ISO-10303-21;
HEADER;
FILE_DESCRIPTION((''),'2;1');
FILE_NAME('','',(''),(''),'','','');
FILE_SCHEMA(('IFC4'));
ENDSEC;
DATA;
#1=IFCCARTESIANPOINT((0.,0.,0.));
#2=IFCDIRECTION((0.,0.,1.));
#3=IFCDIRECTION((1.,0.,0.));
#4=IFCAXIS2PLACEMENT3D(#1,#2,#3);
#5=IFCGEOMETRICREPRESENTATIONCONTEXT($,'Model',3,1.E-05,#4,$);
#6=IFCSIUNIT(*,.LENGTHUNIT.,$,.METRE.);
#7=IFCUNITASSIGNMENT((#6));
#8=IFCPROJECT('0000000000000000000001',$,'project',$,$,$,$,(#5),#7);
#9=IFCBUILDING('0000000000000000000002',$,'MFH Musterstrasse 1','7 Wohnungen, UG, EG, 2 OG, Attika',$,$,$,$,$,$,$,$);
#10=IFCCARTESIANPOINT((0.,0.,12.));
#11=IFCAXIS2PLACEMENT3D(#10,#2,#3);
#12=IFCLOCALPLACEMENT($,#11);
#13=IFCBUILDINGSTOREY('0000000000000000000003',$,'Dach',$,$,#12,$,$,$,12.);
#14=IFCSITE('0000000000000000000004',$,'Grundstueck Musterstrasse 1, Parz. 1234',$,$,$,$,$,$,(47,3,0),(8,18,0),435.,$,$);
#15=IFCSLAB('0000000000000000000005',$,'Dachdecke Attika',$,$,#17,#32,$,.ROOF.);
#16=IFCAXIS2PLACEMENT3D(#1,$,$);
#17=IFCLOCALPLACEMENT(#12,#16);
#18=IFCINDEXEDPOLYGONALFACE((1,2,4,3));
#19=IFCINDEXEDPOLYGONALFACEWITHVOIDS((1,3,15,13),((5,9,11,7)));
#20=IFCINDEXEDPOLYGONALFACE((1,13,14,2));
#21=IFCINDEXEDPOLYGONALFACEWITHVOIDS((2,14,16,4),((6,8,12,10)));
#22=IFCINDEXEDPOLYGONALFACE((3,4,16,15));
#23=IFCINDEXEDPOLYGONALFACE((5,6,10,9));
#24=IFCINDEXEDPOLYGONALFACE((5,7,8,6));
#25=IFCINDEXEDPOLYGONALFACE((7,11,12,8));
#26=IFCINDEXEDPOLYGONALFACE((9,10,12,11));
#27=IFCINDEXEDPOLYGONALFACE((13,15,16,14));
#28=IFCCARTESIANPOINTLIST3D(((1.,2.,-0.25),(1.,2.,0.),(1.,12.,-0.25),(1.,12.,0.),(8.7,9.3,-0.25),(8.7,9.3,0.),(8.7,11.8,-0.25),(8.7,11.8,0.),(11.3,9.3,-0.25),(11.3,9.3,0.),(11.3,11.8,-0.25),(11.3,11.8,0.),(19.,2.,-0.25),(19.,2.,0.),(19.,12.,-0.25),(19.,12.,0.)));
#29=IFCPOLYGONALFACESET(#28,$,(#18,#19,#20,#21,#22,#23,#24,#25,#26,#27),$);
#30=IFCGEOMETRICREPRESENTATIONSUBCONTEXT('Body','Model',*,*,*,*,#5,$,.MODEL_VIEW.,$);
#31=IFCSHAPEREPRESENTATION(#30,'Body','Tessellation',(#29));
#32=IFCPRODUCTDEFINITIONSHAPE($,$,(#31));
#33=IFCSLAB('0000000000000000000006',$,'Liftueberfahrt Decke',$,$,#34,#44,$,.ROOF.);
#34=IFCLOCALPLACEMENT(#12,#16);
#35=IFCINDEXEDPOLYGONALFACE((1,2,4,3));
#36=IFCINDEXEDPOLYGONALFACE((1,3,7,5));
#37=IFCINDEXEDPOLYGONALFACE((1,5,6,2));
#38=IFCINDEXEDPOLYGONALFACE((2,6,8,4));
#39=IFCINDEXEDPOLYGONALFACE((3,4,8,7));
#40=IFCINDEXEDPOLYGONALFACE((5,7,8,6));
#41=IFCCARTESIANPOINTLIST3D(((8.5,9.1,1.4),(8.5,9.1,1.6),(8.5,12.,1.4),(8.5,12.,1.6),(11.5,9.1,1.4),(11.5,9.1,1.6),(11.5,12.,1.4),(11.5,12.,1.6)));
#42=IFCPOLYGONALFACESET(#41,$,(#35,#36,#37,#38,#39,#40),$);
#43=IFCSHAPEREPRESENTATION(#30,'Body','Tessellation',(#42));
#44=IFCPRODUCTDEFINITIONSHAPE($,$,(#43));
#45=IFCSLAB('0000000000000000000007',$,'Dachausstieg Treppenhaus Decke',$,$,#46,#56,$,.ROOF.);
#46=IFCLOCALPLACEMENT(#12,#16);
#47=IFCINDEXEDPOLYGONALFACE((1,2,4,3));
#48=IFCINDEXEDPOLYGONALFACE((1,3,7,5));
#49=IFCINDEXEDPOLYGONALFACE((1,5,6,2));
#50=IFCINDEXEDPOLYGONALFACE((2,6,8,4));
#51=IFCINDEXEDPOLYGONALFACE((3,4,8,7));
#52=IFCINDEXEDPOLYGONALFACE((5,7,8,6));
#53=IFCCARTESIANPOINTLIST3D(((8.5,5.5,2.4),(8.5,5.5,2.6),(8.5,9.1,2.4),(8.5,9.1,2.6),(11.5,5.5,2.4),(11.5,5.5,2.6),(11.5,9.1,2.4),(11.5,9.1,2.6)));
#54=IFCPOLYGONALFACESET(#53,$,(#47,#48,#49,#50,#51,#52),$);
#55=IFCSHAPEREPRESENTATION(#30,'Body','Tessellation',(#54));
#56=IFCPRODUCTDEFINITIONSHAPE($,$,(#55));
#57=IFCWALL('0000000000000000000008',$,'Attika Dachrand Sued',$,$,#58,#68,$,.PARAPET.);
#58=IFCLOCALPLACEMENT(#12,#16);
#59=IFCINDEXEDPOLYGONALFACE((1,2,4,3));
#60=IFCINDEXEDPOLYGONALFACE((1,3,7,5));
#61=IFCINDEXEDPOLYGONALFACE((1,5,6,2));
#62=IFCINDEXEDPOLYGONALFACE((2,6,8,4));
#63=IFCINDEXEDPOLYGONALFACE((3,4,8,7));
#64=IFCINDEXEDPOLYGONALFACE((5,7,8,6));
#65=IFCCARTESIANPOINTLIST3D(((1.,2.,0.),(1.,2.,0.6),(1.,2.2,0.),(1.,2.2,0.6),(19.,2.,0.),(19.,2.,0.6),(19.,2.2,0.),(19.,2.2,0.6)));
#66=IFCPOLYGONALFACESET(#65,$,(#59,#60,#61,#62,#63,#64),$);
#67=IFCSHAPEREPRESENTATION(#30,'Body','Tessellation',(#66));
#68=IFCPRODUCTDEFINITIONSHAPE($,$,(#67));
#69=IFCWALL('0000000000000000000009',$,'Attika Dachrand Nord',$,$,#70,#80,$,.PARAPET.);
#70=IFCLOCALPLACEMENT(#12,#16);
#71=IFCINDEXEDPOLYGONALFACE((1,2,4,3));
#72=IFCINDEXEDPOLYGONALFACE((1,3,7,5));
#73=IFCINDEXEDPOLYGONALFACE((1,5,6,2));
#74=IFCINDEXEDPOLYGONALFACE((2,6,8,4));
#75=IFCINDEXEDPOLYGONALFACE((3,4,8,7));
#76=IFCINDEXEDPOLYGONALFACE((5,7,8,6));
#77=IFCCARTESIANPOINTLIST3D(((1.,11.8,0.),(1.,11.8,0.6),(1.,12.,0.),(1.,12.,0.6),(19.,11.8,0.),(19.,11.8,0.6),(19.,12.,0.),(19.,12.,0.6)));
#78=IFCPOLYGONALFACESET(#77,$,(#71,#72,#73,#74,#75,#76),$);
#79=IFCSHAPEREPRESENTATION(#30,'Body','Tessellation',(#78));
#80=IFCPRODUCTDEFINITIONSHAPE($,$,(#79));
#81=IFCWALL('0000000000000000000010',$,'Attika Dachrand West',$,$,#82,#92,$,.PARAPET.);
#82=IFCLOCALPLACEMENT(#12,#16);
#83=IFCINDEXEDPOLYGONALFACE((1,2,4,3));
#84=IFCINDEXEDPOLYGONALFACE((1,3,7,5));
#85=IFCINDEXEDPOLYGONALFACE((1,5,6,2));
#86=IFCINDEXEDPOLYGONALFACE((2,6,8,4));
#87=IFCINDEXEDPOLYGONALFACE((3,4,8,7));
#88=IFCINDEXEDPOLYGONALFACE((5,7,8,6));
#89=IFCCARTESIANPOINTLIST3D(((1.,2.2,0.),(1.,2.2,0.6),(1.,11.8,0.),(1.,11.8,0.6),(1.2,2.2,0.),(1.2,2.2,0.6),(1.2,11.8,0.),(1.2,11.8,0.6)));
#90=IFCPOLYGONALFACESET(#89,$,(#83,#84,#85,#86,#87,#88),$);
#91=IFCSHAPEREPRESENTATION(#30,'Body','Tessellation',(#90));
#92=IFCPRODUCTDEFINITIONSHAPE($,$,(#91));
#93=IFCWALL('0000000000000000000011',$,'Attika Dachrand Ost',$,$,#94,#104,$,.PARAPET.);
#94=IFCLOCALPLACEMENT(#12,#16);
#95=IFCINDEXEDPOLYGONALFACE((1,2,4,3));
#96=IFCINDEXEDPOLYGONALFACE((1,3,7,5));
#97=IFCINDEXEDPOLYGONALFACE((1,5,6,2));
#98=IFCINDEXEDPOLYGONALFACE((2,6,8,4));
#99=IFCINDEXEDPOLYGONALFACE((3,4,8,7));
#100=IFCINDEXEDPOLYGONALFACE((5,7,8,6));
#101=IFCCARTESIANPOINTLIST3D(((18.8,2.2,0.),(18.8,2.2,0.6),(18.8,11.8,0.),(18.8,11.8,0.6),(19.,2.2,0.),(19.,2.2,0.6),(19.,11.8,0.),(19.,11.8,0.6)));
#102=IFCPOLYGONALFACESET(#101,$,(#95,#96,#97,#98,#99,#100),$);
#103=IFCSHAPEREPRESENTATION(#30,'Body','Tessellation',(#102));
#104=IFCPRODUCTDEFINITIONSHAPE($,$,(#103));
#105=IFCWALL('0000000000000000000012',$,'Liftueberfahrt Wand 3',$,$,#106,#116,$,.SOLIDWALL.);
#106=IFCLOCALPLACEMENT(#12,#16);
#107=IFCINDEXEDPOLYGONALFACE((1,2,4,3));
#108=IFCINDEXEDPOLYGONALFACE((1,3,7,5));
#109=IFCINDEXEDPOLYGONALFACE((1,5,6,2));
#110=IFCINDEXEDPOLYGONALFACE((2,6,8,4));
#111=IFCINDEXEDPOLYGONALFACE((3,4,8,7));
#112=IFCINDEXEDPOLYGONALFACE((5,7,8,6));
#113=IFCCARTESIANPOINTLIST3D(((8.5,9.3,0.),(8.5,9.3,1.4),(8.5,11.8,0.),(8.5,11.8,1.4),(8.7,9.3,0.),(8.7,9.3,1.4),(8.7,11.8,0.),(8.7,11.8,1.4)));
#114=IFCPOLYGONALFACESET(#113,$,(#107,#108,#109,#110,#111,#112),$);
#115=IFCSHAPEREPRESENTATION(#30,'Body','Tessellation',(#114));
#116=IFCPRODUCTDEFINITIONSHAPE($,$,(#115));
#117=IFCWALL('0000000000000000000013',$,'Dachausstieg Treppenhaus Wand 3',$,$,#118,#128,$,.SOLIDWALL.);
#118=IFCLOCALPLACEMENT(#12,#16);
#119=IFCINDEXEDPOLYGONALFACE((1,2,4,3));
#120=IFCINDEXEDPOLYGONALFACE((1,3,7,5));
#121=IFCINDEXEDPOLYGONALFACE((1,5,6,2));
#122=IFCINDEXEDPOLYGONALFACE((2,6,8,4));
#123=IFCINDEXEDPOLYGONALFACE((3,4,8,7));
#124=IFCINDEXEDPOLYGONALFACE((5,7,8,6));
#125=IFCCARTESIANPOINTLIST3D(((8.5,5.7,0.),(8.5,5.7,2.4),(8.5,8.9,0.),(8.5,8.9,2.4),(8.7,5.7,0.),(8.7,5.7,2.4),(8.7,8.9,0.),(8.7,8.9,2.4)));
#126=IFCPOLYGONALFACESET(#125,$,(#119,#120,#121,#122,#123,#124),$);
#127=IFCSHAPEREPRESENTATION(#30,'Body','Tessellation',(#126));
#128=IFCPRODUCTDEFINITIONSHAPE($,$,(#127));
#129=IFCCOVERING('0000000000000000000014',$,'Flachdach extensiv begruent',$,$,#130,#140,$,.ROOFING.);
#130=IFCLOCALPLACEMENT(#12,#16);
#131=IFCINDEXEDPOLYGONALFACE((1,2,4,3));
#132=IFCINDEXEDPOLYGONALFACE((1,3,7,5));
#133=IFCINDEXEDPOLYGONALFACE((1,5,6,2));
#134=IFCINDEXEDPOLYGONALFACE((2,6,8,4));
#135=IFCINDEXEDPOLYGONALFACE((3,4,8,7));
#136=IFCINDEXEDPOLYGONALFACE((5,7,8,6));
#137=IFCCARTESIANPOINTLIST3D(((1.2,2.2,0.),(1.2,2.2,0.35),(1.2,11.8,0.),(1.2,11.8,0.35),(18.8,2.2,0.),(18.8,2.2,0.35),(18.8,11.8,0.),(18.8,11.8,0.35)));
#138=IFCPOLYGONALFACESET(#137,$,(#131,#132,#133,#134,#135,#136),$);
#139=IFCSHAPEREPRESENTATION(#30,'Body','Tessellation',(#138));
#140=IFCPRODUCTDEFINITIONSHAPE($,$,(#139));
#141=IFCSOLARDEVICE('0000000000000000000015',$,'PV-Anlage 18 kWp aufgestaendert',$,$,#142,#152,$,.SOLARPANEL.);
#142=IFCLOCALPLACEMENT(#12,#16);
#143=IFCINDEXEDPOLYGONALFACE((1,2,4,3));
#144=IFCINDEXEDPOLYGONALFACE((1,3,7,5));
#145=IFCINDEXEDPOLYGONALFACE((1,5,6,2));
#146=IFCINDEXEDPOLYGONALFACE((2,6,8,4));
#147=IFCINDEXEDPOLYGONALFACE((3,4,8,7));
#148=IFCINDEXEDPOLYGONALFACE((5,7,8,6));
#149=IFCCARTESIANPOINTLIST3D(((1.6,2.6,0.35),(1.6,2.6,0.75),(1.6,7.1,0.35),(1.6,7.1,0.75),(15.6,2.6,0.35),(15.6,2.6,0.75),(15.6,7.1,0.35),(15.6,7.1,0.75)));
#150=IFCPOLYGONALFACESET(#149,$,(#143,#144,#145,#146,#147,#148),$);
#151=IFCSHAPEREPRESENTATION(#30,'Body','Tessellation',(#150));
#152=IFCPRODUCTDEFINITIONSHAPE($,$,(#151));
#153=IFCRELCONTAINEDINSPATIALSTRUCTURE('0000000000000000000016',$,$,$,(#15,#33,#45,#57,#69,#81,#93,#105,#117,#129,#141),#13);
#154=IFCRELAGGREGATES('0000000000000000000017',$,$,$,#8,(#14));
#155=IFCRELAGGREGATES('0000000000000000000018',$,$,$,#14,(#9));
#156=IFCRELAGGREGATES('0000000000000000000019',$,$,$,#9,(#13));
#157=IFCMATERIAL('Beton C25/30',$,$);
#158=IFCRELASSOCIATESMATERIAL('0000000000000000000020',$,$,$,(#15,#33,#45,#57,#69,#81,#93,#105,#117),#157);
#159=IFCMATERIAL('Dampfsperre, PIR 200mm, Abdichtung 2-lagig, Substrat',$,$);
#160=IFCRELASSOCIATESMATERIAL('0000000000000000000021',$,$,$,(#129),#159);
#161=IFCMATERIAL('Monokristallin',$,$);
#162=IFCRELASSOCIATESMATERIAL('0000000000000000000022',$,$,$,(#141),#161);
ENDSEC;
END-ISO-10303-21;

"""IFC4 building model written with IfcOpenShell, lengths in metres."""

from ifc_helpers import new_model, si_unit, frame, frame_2d, origin_with_axes, place, context, subcontext, project, spatial, polyline, rectangle, outline, extrude, material, element, save


model = new_model("IFC4")

# Units and contexts
model_context = context("Model", 3, precision=1e-05, world=origin_with_axes())
body_context = subcontext(model_context, "Body", "Model", "MODEL_VIEW")
ifc_project = project(units=[si_unit("LENGTHUNIT", "METRE")], contexts=[model_context])

# Site, building, storey
site = spatial("IfcSite", under=ifc_project, Name="Grundstueck Musterstrasse 1, Parz. 1234", RefLatitude=(47, 3, 0), RefLongitude=(8, 18, 0), RefElevation=435.0)
building = spatial("IfcBuilding", under=site, Name="MFH Musterstrasse 1", Description="7 Wohnungen, UG, EG, 2 OG, Attika")
storey_placement = place(None, frame((0.0, 0.0, 12.0), z_axis=(0.0, 0.0, 1.0), x_axis=(1.0, 0.0, 0.0)))
storey = spatial("IfcBuildingStorey", under=building, at=storey_placement, Name="Dach", Elevation=12.0)

# Slab, opening
ifc_material_1 = material(Name="Beton C25/30")
slab_1_placement = place(storey_placement, frame((0.0, 0.0, -0.25), z_axis=(0.0, 0.0, 1.0), x_axis=(1.0, 0.0, 0.0)))
slab_1 = element("IfcSlab", 1, at=slab_1_placement, inside=storey, material=ifc_material_1, Name="Dachdecke Attika", PredefinedType="ROOF", context=body_context, shape_type="SweptSolid", body=[
    extrude(outline(polyline([(1.0, 2.0), (19.0, 2.0), (19.0, 12.0), (1.0, 12.0), (1.0, 2.0)])), origin_with_axes(), (0.0, 0.0, 1.0), 0.25),
])
opening_placement = place(slab_1_placement, frame((8.7, 9.3, -0.01), z_axis=(0.0, 0.0, 1.0), x_axis=(1.0, 0.0, 0.0)))
element("IfcOpeningElement", 2, at=opening_placement, cuts=slab_1, context=body_context, shape_type="SweptSolid", body=[
    extrude(rectangle(XDim=2.6, YDim=2.5, at=frame_2d((1.3, 1.25))), origin_with_axes(), (0.0, 0.0, 1.0), 0.27),
])

# Slabs
slab_2_placement = place(storey_placement, frame((0.0, 0.0, 1.4), z_axis=(0.0, 0.0, 1.0), x_axis=(1.0, 0.0, 0.0)))
element("IfcSlab", 3, at=slab_2_placement, inside=storey, material=ifc_material_1, Name="Liftueberfahrt Decke", PredefinedType="ROOF", context=body_context, shape_type="SweptSolid", body=[
    extrude(outline(polyline([(8.5, 9.1), (11.5, 9.1), (11.5, 12.0), (8.5, 12.0), (8.5, 9.1)])), origin_with_axes(), (0.0, 0.0, 1.0), 0.2),
])
slab_3_placement = place(storey_placement, frame((0.0, 0.0, 2.4), z_axis=(0.0, 0.0, 1.0), x_axis=(1.0, 0.0, 0.0)))
element("IfcSlab", 4, at=slab_3_placement, inside=storey, material=ifc_material_1, Name="Dachausstieg Treppenhaus Decke", PredefinedType="ROOF", context=body_context, shape_type="SweptSolid", body=[
    extrude(outline(polyline([(8.5, 5.5), (11.5, 5.5), (11.5, 9.1), (8.5, 9.1), (8.5, 5.5)])), origin_with_axes(), (0.0, 0.0, 1.0), 0.2),
])

# Walls
for number, where, z_axis, x_axis, name in (
    (5, (1.0, 2.0, 0.0), (0.0, 0.0, 1.0), (1.0, 0.0, 0.0), "Attika Dachrand Sued"),
    (6, (1.0, 11.8, 0.0), (0.0, 0.0, 1.0), (1.0, 0.0, 0.0), "Attika Dachrand Nord"),
):
    element("IfcWall", number, at=place(storey_placement, frame(where, z_axis=z_axis, x_axis=x_axis)), inside=storey, material=ifc_material_1, Name=name, PredefinedType="PARAPET", context=body_context, shape_type="SweptSolid", body=[
        extrude(rectangle(XDim=18.0, YDim=0.2, at=frame_2d((9.0, 0.1))), origin_with_axes(), (0.0, 0.0, 1.0), 0.6),
    ])
for number, where, z_axis, x_axis, name in (
    (7, (1.0, 2.2, 0.0), (0.0, 0.0, 1.0), (1.0, 0.0, 0.0), "Attika Dachrand West"),
    (8, (18.8, 2.2, 0.0), (0.0, 0.0, 1.0), (1.0, 0.0, 0.0), "Attika Dachrand Ost"),
):
    element("IfcWall", number, at=place(storey_placement, frame(where, z_axis=z_axis, x_axis=x_axis)), inside=storey, material=ifc_material_1, Name=name, PredefinedType="PARAPET", context=body_context, shape_type="SweptSolid", body=[
        extrude(rectangle(XDim=0.2, YDim=9.6, at=frame_2d((0.1, 4.8))), origin_with_axes(), (0.0, 0.0, 1.0), 0.6),
    ])
wall_1_placement = place(storey_placement, frame((8.7, 9.3, 0.0), z_axis=(0.0, 0.0, 1.0), x_axis=(1.0, 0.0, 0.0)))
element("IfcWall", 9, at=wall_1_placement, inside=storey, material=ifc_material_1, Name="Liftueberfahrt Wand 3", PredefinedType="SOLIDWALL", context=body_context, shape_type="SweptSolid", body=[
    extrude(rectangle(XDim=0.2, YDim=2.5, at=frame_2d((-0.1, 1.25))), origin_with_axes(), (0.0, 0.0, 1.0), 1.4),
])
wall_2_placement = place(storey_placement, frame((8.7, 5.7, 0.0), z_axis=(0.0, 0.0, 1.0), x_axis=(1.0, 0.0, 0.0)))
element("IfcWall", 10, at=wall_2_placement, inside=storey, material=ifc_material_1, Name="Dachausstieg Treppenhaus Wand 3", PredefinedType="SOLIDWALL", context=body_context, shape_type="SweptSolid", body=[
    extrude(rectangle(XDim=0.2, YDim=3.2, at=frame_2d((-0.1, 1.6))), origin_with_axes(), (0.0, 0.0, 1.0), 2.4),
])

# Covering
ifc_material_2 = material(Name="Dampfsperre, PIR 200mm, Abdichtung 2-lagig, Substrat")
covering_placement = place(storey_placement, origin_with_axes())
element("IfcCovering", 11, at=covering_placement, inside=storey, material=ifc_material_2, Name="Flachdach extensiv begruent", PredefinedType="ROOFING", context=body_context, shape_type="SweptSolid", body=[
    extrude(outline(polyline([(1.2, 2.2), (18.8, 2.2), (18.8, 11.8), (1.2, 11.8), (1.2, 2.2)])), origin_with_axes(), (0.0, 0.0, 1.0), 0.35),
])

# Solar device
ifc_material_3 = material(Name="Monokristallin")
solar_device_placement = place(storey_placement, frame((1.6, 2.6, 0.35), z_axis=(0.0, 0.0, 1.0), x_axis=(1.0, 0.0, 0.0)))
element("IfcSolarDevice", 12, at=solar_device_placement, inside=storey, material=ifc_material_3, Name="PV-Anlage 18 kWp aufgestaendert", PredefinedType="SOLARPANEL", context=body_context, shape_type="SweptSolid", body=[
    extrude(rectangle(XDim=14.0, YDim=4.5, at=frame_2d((7.0, 2.25))), origin_with_axes(), (0.0, 0.0, 1.0), 0.4),
])

save(model, "model.ifc")
